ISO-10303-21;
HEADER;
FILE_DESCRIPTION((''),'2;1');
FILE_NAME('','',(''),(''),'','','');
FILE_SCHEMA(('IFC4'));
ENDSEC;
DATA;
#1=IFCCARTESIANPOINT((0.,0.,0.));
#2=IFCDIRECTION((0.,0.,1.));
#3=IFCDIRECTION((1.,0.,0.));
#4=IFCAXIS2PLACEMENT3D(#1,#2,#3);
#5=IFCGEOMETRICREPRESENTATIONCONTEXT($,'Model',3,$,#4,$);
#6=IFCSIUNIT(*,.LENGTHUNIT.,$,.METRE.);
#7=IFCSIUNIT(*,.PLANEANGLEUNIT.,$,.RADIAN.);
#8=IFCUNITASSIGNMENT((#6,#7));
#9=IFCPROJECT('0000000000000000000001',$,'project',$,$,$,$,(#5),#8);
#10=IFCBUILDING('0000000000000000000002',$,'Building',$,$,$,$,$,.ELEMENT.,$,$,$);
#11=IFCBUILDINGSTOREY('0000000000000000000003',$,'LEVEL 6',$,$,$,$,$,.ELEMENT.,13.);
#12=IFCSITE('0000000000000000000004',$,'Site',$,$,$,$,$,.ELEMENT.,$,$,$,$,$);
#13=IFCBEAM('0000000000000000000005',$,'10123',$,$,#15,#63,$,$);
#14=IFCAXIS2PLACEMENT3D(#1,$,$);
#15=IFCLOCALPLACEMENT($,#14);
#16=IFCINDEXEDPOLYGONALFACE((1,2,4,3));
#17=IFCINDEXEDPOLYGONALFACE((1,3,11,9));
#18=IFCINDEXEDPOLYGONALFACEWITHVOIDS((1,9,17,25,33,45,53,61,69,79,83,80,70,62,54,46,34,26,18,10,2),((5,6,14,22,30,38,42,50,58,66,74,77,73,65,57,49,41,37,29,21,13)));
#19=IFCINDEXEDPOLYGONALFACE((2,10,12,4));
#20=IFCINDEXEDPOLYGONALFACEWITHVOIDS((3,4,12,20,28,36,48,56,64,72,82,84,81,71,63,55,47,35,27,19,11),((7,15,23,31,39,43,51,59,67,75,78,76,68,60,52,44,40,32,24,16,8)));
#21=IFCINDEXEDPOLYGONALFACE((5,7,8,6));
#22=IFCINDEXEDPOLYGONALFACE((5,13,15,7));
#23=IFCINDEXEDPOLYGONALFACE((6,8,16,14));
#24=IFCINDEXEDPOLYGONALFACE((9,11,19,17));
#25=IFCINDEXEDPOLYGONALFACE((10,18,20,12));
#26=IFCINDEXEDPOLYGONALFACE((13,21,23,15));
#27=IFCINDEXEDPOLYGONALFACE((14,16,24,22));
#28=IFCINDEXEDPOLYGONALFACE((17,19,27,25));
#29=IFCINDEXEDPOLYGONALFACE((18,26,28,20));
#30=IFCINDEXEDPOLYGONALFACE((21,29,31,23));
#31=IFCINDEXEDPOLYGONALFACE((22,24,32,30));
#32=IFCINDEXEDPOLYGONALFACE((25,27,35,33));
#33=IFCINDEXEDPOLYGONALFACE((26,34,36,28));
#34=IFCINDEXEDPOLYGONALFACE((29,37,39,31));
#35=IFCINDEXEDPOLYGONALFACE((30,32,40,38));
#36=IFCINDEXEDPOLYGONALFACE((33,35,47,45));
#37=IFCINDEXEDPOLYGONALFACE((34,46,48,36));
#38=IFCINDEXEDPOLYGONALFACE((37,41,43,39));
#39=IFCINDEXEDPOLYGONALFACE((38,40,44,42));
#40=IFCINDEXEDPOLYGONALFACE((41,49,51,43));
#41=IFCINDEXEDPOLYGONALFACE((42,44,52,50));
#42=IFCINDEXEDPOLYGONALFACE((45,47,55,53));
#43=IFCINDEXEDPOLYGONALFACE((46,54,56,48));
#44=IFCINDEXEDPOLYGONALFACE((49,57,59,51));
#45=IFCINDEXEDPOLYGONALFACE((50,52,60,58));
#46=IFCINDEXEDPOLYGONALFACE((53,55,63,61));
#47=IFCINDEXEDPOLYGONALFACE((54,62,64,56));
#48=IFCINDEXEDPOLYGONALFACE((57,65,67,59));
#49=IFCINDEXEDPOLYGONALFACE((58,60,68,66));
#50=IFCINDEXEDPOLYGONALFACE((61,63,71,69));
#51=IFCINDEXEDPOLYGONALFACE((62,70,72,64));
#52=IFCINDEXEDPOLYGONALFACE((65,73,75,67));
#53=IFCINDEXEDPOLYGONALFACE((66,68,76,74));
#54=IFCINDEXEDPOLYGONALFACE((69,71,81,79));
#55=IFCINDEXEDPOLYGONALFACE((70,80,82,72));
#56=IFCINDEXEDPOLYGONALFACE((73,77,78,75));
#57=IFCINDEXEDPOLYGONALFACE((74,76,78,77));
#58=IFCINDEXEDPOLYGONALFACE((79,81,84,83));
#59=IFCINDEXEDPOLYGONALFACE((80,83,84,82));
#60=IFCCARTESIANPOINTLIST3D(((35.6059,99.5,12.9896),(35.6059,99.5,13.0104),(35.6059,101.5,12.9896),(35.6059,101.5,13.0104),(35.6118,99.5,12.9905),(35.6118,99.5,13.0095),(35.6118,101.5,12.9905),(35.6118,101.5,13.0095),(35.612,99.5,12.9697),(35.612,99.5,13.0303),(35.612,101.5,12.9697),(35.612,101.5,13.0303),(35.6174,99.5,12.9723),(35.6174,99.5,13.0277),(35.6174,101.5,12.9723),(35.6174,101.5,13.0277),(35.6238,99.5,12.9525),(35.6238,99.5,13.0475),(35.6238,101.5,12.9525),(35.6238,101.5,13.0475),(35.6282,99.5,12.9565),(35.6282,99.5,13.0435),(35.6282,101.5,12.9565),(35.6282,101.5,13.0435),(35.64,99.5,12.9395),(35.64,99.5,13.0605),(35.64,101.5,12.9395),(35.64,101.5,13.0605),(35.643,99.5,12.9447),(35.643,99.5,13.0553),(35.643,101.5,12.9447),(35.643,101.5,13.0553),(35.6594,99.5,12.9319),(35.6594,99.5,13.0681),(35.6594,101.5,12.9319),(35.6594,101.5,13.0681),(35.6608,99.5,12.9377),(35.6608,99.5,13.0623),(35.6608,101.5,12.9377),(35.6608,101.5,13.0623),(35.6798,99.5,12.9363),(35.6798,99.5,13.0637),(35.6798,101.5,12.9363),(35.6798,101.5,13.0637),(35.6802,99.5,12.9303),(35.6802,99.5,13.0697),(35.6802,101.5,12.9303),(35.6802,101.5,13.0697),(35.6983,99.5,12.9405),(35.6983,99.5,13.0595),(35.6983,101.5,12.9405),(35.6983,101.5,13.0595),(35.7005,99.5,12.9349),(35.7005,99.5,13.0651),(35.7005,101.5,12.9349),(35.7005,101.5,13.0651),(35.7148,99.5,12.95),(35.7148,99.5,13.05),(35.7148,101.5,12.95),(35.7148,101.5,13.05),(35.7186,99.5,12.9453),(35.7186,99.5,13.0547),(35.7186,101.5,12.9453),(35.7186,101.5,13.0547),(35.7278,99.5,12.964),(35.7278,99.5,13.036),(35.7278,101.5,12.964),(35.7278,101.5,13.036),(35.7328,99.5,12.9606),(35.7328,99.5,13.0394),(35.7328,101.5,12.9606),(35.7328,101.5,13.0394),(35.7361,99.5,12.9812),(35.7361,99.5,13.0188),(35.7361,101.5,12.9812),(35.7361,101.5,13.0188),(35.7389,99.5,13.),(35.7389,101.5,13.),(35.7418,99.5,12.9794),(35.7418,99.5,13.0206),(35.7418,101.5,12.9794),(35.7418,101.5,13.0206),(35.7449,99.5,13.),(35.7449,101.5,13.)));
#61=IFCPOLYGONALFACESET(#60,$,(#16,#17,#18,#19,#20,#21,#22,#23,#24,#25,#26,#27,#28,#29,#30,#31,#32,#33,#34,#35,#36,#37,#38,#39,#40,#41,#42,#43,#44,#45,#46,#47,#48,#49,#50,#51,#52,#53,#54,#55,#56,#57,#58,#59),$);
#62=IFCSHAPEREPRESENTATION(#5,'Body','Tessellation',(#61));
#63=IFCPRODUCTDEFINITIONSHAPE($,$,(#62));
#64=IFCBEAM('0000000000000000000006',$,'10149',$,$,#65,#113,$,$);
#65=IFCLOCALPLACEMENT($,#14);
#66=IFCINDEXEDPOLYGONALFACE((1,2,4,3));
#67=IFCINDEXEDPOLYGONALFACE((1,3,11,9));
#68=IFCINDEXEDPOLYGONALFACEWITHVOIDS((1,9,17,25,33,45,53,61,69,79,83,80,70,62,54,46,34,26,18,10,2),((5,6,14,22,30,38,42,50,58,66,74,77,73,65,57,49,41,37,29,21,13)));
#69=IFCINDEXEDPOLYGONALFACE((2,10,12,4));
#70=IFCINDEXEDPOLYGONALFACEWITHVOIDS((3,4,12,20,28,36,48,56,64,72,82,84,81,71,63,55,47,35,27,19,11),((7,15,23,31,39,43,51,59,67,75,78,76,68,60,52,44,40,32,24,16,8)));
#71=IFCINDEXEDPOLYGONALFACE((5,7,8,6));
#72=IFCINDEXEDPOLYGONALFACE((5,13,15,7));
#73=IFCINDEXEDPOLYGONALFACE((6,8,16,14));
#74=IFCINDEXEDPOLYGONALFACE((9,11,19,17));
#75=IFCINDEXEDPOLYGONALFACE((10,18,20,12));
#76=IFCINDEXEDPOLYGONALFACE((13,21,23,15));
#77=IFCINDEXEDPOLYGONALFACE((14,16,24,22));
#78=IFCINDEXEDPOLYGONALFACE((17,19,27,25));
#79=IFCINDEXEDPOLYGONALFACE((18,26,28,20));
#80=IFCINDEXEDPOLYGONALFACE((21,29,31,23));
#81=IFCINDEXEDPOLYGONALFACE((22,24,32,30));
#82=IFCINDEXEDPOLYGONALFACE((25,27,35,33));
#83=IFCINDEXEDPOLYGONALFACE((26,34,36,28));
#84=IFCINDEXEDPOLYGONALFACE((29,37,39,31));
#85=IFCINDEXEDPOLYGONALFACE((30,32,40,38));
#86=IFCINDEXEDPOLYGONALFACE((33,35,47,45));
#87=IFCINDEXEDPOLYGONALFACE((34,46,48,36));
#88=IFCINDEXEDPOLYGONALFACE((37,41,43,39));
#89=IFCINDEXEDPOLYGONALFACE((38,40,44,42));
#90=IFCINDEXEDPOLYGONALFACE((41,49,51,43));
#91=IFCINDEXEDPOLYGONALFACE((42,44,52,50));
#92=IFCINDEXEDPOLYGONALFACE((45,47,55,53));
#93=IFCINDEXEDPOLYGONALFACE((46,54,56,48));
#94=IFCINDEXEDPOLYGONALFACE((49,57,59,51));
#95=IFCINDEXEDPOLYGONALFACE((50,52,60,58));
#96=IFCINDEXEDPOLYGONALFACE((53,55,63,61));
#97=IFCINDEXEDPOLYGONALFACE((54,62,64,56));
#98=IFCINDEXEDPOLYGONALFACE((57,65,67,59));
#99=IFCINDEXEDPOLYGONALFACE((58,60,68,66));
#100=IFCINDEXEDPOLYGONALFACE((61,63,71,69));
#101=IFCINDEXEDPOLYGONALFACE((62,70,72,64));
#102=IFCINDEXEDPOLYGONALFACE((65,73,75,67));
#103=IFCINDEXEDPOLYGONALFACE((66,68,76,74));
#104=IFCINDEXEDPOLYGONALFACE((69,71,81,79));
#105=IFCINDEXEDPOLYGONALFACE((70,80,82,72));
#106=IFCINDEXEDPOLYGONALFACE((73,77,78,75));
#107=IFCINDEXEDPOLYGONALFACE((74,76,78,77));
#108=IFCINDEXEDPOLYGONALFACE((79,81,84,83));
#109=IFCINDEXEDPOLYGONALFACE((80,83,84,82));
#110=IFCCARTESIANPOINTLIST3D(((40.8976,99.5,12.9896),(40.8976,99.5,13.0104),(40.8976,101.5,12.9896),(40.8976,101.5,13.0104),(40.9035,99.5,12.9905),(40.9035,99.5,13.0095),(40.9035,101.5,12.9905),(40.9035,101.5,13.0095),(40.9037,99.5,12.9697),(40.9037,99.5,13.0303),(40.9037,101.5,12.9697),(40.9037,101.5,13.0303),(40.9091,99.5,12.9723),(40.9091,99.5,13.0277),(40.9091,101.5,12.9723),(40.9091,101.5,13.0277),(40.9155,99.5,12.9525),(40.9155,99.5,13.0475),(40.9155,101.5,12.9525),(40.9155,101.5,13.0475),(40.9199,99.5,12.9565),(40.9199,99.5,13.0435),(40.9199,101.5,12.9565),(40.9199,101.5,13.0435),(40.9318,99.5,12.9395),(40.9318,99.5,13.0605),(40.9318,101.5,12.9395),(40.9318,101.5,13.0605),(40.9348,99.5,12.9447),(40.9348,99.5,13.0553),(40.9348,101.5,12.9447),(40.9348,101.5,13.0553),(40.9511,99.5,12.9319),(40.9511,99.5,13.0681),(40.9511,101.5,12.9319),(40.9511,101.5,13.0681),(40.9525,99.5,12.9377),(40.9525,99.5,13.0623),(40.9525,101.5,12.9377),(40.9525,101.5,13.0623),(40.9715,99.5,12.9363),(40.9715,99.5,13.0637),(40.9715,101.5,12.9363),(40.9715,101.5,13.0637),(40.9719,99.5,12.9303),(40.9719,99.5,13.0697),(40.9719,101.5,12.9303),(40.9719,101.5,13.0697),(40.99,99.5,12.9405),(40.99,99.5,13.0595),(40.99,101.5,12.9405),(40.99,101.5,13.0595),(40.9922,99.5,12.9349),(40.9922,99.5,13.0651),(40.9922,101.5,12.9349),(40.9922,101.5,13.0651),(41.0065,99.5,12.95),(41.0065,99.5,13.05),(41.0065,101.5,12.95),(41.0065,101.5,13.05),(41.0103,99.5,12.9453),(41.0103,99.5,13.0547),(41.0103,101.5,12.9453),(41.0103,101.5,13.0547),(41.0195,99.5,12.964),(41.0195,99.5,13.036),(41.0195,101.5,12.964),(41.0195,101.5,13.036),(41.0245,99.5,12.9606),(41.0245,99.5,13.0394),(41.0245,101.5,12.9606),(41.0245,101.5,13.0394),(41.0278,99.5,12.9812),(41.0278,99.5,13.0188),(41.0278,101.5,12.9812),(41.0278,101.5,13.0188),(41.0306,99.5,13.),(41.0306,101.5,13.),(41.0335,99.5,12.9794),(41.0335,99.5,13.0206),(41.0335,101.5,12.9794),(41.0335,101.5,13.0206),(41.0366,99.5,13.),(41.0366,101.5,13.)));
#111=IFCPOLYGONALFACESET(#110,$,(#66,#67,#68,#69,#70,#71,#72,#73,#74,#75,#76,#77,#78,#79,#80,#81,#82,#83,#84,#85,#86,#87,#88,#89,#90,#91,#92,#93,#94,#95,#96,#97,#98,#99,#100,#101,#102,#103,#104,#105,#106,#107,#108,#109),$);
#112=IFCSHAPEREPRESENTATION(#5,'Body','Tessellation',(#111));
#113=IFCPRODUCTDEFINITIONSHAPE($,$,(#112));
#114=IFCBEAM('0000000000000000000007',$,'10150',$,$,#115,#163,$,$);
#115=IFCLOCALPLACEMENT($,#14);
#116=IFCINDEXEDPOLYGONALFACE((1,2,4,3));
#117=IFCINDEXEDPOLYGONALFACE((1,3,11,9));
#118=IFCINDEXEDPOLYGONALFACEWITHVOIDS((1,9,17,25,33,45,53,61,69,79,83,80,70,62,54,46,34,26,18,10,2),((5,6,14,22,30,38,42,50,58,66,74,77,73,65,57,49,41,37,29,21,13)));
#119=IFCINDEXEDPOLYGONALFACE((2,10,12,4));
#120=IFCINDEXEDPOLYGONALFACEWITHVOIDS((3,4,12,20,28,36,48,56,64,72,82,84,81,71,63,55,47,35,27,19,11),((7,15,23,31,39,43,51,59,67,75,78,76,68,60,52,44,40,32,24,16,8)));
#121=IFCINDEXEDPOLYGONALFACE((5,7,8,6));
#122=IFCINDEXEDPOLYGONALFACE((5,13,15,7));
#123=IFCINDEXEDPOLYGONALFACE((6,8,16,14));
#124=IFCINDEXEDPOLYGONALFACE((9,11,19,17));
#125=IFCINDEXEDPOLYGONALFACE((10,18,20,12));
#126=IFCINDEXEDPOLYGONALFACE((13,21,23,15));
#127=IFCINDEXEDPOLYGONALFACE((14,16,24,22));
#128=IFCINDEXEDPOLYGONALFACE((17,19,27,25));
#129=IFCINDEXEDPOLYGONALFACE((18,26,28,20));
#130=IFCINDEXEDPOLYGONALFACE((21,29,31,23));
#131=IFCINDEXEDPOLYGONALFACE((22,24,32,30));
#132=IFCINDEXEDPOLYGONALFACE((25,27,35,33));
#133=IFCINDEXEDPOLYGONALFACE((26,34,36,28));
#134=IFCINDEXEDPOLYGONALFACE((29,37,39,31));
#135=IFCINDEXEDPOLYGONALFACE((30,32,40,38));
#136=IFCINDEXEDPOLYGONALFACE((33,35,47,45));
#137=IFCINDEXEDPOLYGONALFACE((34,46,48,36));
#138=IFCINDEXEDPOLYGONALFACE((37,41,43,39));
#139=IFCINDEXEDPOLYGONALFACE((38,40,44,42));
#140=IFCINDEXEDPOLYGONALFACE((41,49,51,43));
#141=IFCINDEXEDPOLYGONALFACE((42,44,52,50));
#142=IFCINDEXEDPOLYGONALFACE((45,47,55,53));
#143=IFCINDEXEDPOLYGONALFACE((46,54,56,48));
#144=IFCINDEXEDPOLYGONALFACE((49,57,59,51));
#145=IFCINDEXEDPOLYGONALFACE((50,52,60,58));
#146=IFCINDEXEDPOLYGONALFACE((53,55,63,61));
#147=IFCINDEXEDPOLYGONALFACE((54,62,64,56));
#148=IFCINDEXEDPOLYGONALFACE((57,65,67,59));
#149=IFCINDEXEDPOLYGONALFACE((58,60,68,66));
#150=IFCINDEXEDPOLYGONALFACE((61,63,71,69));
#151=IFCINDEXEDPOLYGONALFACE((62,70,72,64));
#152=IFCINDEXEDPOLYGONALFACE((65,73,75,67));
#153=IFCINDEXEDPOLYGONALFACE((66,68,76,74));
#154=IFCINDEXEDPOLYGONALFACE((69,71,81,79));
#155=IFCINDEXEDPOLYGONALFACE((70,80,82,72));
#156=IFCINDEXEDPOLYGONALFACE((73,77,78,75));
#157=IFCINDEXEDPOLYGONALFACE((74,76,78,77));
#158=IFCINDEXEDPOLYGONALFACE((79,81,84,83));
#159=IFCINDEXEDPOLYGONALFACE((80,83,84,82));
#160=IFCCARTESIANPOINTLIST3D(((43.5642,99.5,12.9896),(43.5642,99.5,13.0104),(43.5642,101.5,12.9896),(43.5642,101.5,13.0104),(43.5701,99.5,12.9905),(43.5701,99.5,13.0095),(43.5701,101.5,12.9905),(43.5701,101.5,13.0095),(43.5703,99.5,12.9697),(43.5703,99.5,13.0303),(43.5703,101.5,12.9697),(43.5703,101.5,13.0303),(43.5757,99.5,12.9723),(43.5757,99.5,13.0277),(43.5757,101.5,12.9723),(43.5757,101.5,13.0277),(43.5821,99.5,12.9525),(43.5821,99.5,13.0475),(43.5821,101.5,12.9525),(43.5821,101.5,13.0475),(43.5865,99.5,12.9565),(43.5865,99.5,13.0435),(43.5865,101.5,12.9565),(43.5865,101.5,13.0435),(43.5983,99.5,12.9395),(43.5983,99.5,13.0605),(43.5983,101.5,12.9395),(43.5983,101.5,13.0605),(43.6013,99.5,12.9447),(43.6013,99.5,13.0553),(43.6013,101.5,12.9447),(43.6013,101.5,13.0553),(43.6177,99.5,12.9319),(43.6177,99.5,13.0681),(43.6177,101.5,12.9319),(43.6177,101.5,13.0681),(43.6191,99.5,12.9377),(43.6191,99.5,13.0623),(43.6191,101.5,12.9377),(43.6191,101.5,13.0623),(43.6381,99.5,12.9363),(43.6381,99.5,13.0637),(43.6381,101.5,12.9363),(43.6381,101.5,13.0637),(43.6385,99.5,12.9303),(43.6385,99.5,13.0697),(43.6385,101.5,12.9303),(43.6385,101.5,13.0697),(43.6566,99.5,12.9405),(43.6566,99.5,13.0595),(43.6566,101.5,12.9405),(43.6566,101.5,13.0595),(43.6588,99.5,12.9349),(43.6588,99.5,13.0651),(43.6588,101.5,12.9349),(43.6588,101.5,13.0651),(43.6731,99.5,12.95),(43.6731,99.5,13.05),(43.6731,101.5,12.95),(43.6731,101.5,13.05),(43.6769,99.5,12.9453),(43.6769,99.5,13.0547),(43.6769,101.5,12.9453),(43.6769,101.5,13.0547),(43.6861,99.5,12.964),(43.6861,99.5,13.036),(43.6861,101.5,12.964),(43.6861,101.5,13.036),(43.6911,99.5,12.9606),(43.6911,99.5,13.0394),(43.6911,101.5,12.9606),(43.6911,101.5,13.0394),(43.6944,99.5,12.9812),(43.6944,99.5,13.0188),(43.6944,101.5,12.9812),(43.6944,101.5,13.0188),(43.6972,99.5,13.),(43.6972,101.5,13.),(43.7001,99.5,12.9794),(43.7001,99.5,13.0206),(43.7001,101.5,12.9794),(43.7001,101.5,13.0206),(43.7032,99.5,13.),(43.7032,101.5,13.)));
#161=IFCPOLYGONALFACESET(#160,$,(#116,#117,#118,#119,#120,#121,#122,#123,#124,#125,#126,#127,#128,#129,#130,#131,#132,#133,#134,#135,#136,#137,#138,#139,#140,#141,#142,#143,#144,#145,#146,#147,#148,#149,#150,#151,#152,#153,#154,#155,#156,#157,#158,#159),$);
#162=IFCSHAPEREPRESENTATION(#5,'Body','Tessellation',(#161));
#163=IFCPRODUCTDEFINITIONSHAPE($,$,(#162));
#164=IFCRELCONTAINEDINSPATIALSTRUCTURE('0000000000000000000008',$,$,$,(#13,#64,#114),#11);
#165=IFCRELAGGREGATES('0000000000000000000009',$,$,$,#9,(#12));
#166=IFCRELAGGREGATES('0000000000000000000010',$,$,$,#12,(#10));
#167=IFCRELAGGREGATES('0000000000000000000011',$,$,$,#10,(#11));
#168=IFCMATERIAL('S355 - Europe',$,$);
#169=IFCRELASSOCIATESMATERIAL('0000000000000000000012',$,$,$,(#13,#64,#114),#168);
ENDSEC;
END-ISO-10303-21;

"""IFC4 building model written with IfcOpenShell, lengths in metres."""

from ifc_helpers import new_model, si_unit, frame, origin_with_axes, origin_2d_with_axis, place, context, project, spatial, hollow_circle, extrude, material, material_profile, profile_set, profile_usage, element, save


model = new_model("IFC4")

# Units and contexts
model_context = context("Model", 3, world=origin_with_axes())
ifc_project = project(units=[si_unit("LENGTHUNIT", "METRE"), si_unit("PLANEANGLEUNIT", "RADIAN")], contexts=[model_context])

# Site, building, storey
site = spatial("IfcSite", under=ifc_project, Name="Site", CompositionType="ELEMENT")
building = spatial("IfcBuilding", under=site, Name="Building", CompositionType="ELEMENT")
storey = spatial("IfcBuildingStorey", under=building, Name="LEVEL 6", CompositionType="ELEMENT", Elevation=13.0)

# Shared definitions
ifc_material = material(Name="S355 - Europe")

# Beams
ifc_material_profile_1 = material_profile(ifc_material, hollow_circle(Radius=0.0699, WallThickness=0.006, at=origin_2d_with_axis()))
ifc_profile_set_1 = profile_set([ifc_material_profile_1])
ifc_profile_usage_1 = profile_usage(ifc_profile_set_1, cardinal=10)
beam_1_placement = place(None, frame((35.675, 101.5, 13.0), z_axis=(0.0, -1.0, 0.0), x_axis=(1.0, 0.0, 0.0)))
element("IfcBeam", 1, at=beam_1_placement, inside=storey, material=ifc_profile_usage_1, Name="10123", context=model_context, shape_type="SweptSolid", body=[
    extrude(hollow_circle(Radius=0.0699, WallThickness=0.006, at=origin_2d_with_axis()), origin_with_axes(), (0.0, 0.0, 1.0), 2.0),
])
ifc_material_profile_2 = material_profile(ifc_material, hollow_circle(Radius=0.0699, WallThickness=0.006, at=origin_2d_with_axis()))
ifc_profile_set_2 = profile_set([ifc_material_profile_2])
ifc_profile_usage_2 = profile_usage(ifc_profile_set_2, cardinal=10)
beam_2_placement = place(None, frame((40.9667, 101.5, 13.0), z_axis=(0.0, -1.0, 0.0), x_axis=(1.0, 0.0, 0.0)))
element("IfcBeam", 2, at=beam_2_placement, inside=storey, material=ifc_profile_usage_2, Name="10149", context=model_context, shape_type="SweptSolid", body=[
    extrude(hollow_circle(Radius=0.0699, WallThickness=0.006, at=origin_2d_with_axis()), origin_with_axes(), (0.0, 0.0, 1.0), 2.0),
])
ifc_material_profile_3 = material_profile(ifc_material, hollow_circle(Radius=0.0699, WallThickness=0.006, at=origin_2d_with_axis()))
ifc_profile_set_3 = profile_set([ifc_material_profile_3])
ifc_profile_usage_3 = profile_usage(ifc_profile_set_3, cardinal=10)
beam_3_placement = place(None, frame((43.6333, 101.5, 13.0), z_axis=(0.0, -1.0, 0.0), x_axis=(1.0, 0.0, 0.0)))
element("IfcBeam", 3, at=beam_3_placement, inside=storey, material=ifc_profile_usage_3, Name="10150", context=model_context, shape_type="SweptSolid", body=[
    extrude(hollow_circle(Radius=0.0699, WallThickness=0.006, at=origin_2d_with_axis()), origin_with_axes(), (0.0, 0.0, 1.0), 2.0),
])

save(model, "model.ifc")
